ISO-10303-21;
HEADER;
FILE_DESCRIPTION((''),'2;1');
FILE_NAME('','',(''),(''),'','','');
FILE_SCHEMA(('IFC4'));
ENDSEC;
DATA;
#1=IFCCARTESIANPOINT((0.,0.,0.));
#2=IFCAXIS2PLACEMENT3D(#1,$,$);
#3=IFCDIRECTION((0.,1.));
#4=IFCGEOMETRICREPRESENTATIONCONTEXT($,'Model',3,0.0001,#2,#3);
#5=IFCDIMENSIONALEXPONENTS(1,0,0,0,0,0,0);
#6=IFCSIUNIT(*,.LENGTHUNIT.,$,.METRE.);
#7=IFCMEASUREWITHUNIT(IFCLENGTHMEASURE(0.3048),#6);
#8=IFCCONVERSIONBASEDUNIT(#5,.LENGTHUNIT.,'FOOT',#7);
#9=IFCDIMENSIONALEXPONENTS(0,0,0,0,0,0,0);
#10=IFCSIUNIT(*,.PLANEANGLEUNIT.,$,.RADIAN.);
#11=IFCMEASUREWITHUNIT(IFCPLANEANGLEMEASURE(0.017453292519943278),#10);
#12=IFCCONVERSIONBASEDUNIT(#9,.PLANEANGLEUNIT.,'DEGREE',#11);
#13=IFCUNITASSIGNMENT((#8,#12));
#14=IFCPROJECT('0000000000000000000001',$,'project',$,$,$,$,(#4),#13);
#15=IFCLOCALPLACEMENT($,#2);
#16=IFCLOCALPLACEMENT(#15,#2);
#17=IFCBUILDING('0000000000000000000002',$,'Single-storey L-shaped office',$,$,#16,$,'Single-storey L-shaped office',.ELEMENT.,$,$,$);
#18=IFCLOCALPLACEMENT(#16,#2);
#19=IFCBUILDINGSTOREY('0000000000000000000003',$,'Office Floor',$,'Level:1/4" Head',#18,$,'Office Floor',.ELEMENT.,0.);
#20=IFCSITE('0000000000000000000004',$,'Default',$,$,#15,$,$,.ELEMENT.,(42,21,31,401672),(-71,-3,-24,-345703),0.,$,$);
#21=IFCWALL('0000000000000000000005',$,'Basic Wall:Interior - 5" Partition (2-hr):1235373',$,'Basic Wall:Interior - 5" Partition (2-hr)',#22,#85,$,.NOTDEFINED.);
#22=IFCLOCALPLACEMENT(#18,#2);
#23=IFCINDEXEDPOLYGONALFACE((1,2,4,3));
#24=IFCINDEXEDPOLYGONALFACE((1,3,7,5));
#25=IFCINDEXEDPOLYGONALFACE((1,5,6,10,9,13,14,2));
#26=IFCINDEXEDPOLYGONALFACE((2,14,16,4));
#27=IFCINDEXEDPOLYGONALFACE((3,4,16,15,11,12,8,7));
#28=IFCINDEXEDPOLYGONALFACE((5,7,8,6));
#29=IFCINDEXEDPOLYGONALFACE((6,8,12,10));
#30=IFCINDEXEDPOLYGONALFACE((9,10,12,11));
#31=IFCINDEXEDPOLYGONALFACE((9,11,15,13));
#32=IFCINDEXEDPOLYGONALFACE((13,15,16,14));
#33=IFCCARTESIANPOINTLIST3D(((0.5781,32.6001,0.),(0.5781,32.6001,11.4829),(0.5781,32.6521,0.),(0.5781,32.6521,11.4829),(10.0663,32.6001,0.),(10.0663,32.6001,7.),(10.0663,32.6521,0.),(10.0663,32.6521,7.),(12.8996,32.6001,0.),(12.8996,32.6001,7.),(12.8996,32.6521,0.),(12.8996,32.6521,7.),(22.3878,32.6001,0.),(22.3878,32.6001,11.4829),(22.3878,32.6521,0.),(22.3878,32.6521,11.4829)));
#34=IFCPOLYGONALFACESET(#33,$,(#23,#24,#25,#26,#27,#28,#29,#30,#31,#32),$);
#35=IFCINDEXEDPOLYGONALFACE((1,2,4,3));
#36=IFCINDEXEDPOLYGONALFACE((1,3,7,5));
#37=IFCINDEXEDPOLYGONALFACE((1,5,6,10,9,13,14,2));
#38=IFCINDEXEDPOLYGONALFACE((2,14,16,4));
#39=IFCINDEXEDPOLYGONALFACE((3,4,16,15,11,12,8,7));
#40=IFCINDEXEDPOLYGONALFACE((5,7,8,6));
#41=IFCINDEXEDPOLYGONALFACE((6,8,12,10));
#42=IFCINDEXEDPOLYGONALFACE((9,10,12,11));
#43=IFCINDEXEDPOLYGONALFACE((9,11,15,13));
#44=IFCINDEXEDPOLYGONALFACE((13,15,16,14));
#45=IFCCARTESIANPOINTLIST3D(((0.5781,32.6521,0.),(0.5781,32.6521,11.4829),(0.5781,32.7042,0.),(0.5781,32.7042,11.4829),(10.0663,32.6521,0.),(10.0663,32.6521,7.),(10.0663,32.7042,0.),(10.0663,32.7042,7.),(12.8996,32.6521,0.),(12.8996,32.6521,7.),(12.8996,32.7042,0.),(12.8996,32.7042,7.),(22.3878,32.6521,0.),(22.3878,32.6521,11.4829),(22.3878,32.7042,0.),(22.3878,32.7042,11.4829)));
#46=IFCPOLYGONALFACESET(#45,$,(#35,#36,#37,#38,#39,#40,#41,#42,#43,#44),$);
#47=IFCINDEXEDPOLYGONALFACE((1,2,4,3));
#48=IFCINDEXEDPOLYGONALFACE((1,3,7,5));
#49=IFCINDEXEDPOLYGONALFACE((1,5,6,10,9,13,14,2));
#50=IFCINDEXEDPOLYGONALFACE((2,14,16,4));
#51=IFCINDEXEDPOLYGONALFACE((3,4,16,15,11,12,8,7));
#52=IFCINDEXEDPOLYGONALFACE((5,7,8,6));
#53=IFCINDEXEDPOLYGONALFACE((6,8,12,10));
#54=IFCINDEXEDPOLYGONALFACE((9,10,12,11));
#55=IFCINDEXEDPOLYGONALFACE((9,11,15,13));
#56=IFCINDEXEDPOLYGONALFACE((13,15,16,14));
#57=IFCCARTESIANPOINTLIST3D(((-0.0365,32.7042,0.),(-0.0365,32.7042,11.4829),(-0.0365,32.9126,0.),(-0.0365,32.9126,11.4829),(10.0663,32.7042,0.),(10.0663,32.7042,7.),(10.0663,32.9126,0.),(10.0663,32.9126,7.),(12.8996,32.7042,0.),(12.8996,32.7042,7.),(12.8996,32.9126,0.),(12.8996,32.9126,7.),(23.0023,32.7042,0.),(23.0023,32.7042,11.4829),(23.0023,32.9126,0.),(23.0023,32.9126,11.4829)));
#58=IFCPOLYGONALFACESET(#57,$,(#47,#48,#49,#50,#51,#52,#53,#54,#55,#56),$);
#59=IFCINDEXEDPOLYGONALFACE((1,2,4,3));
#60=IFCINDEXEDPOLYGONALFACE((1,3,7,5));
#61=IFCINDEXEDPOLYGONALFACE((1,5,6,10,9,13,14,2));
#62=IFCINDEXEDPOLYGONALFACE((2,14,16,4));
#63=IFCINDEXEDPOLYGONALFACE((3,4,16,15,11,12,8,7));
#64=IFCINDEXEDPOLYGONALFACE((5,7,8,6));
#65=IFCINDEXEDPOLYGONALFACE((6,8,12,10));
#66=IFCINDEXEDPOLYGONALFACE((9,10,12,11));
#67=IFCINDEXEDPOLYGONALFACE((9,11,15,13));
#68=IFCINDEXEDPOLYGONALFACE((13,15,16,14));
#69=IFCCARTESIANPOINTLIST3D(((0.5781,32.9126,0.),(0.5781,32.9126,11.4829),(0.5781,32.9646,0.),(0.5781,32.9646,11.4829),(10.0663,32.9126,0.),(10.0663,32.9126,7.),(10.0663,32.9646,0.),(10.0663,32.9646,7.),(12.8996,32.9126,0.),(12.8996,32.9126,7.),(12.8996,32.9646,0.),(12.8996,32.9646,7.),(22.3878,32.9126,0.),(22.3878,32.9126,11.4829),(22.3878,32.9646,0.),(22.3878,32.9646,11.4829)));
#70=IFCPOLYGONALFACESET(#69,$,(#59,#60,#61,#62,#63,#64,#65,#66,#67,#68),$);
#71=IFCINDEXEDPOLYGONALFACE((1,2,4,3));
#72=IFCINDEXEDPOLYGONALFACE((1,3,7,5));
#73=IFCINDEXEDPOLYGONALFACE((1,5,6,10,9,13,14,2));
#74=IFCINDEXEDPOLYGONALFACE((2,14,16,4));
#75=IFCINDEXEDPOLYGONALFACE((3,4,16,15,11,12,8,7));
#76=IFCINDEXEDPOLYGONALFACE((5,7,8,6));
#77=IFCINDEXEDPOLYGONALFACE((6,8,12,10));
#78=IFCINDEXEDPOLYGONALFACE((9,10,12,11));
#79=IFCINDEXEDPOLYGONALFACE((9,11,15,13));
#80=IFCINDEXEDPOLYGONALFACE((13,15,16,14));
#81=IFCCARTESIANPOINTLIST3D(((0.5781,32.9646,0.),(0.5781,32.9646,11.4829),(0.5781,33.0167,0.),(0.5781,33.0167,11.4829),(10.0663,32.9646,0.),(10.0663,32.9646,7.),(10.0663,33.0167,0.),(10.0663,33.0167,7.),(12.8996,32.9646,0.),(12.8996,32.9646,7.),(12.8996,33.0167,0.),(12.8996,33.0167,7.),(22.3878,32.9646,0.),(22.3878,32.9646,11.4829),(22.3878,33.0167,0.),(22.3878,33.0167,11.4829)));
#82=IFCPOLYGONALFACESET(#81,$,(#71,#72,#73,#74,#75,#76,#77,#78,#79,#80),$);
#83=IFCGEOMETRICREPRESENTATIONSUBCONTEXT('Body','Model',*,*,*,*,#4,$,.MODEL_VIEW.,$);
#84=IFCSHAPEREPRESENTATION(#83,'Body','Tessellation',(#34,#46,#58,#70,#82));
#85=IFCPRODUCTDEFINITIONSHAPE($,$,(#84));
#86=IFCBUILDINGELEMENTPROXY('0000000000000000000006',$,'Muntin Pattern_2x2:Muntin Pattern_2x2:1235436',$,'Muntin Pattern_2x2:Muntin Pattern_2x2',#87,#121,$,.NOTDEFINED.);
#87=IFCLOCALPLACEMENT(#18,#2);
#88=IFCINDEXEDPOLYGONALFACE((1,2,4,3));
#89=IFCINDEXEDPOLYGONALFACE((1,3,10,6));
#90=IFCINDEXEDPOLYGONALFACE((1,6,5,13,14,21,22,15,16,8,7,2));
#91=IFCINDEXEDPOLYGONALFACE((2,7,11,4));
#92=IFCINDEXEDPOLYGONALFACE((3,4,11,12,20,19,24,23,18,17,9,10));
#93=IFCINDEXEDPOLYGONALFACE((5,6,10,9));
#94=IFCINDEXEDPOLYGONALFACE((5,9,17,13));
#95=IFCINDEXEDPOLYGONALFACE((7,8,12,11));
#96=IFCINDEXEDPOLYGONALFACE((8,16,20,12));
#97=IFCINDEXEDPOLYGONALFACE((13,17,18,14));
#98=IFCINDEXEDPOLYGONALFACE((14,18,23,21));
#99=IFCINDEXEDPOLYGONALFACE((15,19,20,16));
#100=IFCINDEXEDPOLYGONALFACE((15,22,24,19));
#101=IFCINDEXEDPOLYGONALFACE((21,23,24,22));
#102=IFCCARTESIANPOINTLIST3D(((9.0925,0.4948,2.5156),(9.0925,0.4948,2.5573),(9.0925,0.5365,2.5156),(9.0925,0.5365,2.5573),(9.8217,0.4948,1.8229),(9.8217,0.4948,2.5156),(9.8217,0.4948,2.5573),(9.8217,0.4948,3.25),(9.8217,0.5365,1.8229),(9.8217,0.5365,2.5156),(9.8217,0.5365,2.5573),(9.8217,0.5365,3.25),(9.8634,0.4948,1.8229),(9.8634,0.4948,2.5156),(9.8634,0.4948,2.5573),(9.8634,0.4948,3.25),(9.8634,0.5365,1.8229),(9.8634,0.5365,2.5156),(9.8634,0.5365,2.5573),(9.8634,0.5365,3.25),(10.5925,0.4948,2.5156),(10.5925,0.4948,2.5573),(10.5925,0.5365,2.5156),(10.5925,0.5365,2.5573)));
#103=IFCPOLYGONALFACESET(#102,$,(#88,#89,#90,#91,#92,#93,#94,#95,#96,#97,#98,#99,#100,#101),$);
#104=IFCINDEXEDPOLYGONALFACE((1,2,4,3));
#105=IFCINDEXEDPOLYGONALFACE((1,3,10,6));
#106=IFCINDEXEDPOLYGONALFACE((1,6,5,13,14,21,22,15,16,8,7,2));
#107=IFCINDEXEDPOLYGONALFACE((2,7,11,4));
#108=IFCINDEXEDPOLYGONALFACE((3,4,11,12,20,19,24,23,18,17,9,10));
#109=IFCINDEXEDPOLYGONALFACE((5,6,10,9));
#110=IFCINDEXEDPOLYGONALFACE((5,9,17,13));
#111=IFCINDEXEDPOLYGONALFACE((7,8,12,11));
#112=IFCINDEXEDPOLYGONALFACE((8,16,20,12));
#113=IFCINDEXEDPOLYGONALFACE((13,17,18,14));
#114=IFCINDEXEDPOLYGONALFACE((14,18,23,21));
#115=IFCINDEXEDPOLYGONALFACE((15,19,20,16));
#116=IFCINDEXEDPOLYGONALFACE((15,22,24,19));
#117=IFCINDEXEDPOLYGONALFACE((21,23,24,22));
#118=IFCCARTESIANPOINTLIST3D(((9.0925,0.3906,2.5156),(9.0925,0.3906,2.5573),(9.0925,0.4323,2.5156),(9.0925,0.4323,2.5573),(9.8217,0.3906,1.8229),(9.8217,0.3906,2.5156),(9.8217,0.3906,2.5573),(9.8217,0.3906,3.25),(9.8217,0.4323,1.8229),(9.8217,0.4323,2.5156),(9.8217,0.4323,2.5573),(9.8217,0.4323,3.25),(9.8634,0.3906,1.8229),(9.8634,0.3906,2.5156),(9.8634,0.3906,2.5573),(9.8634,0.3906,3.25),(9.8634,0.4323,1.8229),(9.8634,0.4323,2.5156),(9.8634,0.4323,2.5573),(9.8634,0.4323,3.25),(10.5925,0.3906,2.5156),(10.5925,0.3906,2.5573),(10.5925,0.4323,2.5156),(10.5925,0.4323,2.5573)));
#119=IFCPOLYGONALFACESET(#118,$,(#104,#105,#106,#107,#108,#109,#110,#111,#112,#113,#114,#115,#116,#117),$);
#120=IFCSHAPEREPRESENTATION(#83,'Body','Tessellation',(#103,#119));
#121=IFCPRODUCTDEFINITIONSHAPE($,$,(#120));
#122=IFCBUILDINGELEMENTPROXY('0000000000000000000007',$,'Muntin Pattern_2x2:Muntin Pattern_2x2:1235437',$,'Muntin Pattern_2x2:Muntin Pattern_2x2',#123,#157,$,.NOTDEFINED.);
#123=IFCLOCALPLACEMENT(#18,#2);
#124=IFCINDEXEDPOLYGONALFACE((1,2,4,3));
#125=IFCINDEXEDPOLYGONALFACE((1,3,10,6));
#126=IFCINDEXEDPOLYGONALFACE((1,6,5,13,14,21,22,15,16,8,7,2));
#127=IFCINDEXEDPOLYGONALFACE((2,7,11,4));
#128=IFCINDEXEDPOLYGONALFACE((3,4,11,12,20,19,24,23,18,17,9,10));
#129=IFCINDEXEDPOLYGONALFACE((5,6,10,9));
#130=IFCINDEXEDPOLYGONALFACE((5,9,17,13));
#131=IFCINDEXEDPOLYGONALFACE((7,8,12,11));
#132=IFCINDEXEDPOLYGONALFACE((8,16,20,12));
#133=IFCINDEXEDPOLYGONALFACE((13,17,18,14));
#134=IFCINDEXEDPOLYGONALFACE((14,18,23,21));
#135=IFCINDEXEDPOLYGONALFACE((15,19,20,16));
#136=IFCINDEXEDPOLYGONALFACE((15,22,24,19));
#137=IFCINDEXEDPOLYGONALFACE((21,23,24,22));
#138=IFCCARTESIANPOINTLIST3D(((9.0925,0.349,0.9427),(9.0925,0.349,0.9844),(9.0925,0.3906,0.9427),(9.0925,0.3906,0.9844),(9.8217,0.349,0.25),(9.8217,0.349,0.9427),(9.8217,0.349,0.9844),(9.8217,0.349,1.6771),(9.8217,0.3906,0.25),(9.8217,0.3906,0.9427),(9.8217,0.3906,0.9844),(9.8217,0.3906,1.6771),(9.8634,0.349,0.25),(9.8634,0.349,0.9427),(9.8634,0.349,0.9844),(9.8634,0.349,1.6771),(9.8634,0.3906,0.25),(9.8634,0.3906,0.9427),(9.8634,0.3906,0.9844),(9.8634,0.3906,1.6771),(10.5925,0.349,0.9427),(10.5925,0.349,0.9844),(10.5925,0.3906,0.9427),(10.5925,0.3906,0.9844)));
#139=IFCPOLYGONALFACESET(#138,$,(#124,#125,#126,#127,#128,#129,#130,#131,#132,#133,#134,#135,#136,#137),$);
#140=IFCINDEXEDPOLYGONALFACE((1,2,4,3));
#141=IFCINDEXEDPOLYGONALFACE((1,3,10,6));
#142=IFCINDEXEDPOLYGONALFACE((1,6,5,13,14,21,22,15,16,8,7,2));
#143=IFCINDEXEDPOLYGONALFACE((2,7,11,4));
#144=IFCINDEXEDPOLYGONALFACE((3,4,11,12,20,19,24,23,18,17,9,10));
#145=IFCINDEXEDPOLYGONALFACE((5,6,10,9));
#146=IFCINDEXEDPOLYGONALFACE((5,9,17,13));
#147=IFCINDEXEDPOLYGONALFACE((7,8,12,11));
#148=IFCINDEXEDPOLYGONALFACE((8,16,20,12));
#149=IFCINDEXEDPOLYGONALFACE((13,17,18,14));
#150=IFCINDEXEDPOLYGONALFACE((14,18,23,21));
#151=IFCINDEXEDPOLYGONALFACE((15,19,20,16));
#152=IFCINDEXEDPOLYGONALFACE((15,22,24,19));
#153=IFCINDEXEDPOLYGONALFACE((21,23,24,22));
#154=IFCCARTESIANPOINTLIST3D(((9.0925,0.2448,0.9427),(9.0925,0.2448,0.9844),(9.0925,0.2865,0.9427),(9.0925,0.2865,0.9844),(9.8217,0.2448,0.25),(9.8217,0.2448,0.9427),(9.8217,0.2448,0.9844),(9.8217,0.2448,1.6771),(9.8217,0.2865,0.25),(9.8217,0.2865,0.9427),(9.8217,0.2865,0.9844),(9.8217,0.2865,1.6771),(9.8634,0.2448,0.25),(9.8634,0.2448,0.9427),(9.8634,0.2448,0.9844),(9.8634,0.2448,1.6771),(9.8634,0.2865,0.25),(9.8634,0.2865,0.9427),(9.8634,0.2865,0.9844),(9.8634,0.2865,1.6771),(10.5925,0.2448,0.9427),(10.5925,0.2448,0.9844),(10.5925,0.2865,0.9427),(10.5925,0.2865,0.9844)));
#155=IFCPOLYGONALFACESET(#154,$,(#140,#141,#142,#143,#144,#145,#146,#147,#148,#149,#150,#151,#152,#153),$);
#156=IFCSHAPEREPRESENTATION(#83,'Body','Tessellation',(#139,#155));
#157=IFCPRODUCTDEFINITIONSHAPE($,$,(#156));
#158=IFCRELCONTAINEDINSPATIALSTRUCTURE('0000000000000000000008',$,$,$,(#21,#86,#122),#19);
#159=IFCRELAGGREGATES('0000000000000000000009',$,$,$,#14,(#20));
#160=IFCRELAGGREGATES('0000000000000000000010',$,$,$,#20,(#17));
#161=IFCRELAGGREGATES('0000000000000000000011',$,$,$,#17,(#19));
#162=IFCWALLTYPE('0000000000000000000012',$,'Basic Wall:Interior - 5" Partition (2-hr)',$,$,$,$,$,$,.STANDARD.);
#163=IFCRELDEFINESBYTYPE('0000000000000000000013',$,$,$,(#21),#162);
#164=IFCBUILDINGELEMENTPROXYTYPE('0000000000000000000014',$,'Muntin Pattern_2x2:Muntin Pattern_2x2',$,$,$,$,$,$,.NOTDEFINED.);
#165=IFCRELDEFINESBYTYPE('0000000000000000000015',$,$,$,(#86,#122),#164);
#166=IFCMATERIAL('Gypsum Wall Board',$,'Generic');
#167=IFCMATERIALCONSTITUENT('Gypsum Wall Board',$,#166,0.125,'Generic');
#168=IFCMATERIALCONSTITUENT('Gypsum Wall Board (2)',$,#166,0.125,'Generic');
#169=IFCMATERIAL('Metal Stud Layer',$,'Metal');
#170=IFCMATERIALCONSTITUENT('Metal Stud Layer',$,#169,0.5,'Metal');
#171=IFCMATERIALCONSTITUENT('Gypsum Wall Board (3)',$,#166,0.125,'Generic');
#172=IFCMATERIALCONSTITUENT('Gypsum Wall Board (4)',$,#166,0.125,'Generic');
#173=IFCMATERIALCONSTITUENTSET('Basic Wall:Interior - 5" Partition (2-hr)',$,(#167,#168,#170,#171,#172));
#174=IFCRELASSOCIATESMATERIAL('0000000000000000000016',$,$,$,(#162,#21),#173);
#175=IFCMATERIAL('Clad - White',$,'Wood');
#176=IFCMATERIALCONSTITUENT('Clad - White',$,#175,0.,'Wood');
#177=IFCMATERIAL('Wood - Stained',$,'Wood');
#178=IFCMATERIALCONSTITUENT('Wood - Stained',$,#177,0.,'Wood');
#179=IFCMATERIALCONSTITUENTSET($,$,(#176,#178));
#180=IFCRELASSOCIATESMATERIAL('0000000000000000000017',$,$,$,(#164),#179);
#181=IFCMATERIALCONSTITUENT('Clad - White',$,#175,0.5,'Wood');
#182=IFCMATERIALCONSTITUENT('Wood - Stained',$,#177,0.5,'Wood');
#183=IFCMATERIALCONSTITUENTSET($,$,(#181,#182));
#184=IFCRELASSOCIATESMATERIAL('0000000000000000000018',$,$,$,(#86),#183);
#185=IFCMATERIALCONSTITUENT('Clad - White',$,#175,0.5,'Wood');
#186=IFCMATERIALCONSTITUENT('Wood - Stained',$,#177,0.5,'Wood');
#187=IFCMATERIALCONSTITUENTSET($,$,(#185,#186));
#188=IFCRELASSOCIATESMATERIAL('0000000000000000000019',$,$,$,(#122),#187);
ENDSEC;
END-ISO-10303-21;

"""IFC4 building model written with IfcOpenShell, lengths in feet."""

from ifc_helpers import new_model, entity, si_unit, converted_unit, direction, frame, origin, place, context, subcontext, project, spatial, indexed_curve, outline, extrude, source, transform, mapped, material, constituent, constituent_set, type_object, type_shapes, element, save


model = new_model("IFC4")

# Units and contexts
model_context = context("Model", 3, precision=0.0001, world=origin(), true_north=direction((0.0, 1.0)))
body_context = subcontext(model_context, "Body", "Model", "MODEL_VIEW")
ifc_project = project(units=[converted_unit("LENGTHUNIT", "FOOT", entity("IfcLengthMeasure", 0.3048), si_unit("LENGTHUNIT", "METRE"), dimensions=[1, 0, 0, 0, 0, 0, 0]), converted_unit("PLANEANGLEUNIT", "DEGREE", entity("IfcPlaneAngleMeasure", 0.017453292519943278), si_unit("PLANEANGLEUNIT", "RADIAN"), dimensions=[0, 0, 0, 0, 0, 0, 0])], contexts=[model_context])

# Site, building, storey
site_placement = place(None, origin())
site = spatial("IfcSite", under=ifc_project, at=site_placement, Name="Default", CompositionType="ELEMENT", RefLatitude=(42, 21, 31, 401672), RefLongitude=(-71, -3, -24, -345703), RefElevation=0.0)
building_placement = place(site_placement, origin())
building = spatial("IfcBuilding", under=site, at=building_placement, Name="Single-storey L-shaped office", LongName="Single-storey L-shaped office", CompositionType="ELEMENT")
storey_placement = place(building_placement, origin())
storey = spatial("IfcBuildingStorey", under=building, at=storey_placement, Name="Office Floor", ObjectType="Level:1/4\" Head", LongName="Office Floor", CompositionType="ELEMENT", Elevation=0.0)

# Shared definitions
ifc_material_1 = material(Name="Metal Stud Layer", Category="Metal")
ifc_material_2 = material(Name="Gypsum Wall Board", Category="Generic")
ifc_material_3 = material(Name="Wood - Stained", Category="Wood")

# Wall, opening
ifc_constituent_1 = constituent(ifc_material_2, Name="Gypsum Wall Board", Category="Generic", fraction=0.125)
ifc_constituent_2 = constituent(ifc_material_2, Name="Gypsum Wall Board (2)", Category="Generic", fraction=0.125)
ifc_constituent_3 = constituent(ifc_material_1, Name="Metal Stud Layer", Category="Metal", fraction=0.5)
ifc_constituent_4 = constituent(ifc_material_2, Name="Gypsum Wall Board (3)", Category="Generic", fraction=0.125)
ifc_constituent_5 = constituent(ifc_material_2, Name="Gypsum Wall Board (4)", Category="Generic", fraction=0.125)
ifc_constituent_set_1 = constituent_set(constituents=[ifc_constituent_1, ifc_constituent_2, ifc_constituent_3, ifc_constituent_4, ifc_constituent_5], Name="Basic Wall:Interior - 5\" Partition (2-hr)")
wall_type_1 = type_object("IfcWallType", Name="Basic Wall:Interior - 5\" Partition (2-hr)", PredefinedType="STANDARD", material=ifc_constituent_set_1)
wall_1_placement = place(storey_placement, frame((0.5781, 32.8084, 0.0)))
wall_1 = element("IfcWall", 1, at=wall_1_placement, inside=storey, type_object=wall_type_1, material=ifc_constituent_set_1, Name="Basic Wall:Interior - 5\" Partition (2-hr):1235373", ObjectType="Basic Wall:Interior - 5\" Partition (2-hr)", PredefinedType="NOTDEFINED", context=body_context, shape_type="SweptSolid", body=[
    extrude(outline(indexed_curve([(-6.8622, -10.9048), (4.6207, -10.9048), (4.6207, -1.4167), (-2.3793, -1.4167), (-2.3793, 1.4167), (4.6207, 1.4167), (4.6207, 10.9048), (-6.8622, 10.9048), (-6.8622, -10.9048)], self_intersect=False)), frame((10.9048, -0.2083, 4.6207), z_axis=(0.0, 1.0, 0.0), x_axis=(0.0, 0.0, -1.0)), (0.0, 0.0, 1.0), 0.0521),
    extrude(outline(indexed_curve([(-4.6207, -10.9048), (6.8622, -10.9048), (6.8622, 10.9048), (-4.6207, 10.9048), (-4.6207, 1.4167), (2.3793, 1.4167), (2.3793, -1.4167), (-4.6207, -1.4167), (-4.6207, -10.9048)], self_intersect=False)), frame((10.9048, -0.1562, 4.6207), z_axis=(0.0, 1.0, 0.0), x_axis=(0.0, 0.0, 1.0)), (0.0, 0.0, 1.0), 0.0521),
    extrude(outline(indexed_curve([(-4.6207, -11.5194), (6.8622, -11.5194), (6.8622, 11.5194), (-4.6207, 11.5194), (-4.6207, 1.4167), (2.3793, 1.4167), (2.3793, -1.4167), (-4.6207, -1.4167), (-4.6207, -11.5194)], self_intersect=False)), frame((10.9048, -0.1042, 4.6207), z_axis=(0.0, 1.0, 0.0), x_axis=(0.0, 0.0, 1.0)), (0.0, 0.0, 1.0), 0.2083),
    extrude(outline(indexed_curve([(-4.6207, -10.9048), (6.8622, -10.9048), (6.8622, 10.9048), (-4.6207, 10.9048), (-4.6207, 1.4167), (2.3793, 1.4167), (2.3793, -1.4167), (-4.6207, -1.4167), (-4.6207, -10.9048)], self_intersect=False)), frame((10.9048, 0.1042, 4.6207), z_axis=(0.0, 1.0, 0.0), x_axis=(0.0, 0.0, 1.0)), (0.0, 0.0, 1.0), 0.0521),
    extrude(outline(indexed_curve([(-4.6207, -10.9048), (6.8622, -10.9048), (6.8622, 10.9048), (-4.6207, 10.9048), (-4.6207, 1.4167), (2.3793, 1.4167), (2.3793, -1.4167), (-4.6207, -1.4167), (-4.6207, -10.9048)], self_intersect=False)), frame((10.9048, 0.1562, 4.6207), z_axis=(0.0, 1.0, 0.0), x_axis=(0.0, 0.0, 1.0)), (0.0, 0.0, 1.0), 0.0521),
])
opening_1_placement = place(wall_1_placement, frame((9.4881, -0.2083, 0.0)))
element("IfcOpeningElement", 2, at=opening_1_placement, cuts=wall_1, PredefinedType="OPENING", context=body_context, shape_type="SweptSolid", body=[
    extrude(outline(indexed_curve([(0.0, 2.8333), (0.0, 0.0), (7.0, 0.0), (7.0, 2.8333), (0.0, 2.8333)], self_intersect=False)), frame((0.0, 0.0, 0.0), z_axis=(0.0, 1.0, 0.0), x_axis=(0.0, 0.0, 1.0)), (0.0, 0.0, 1.0), 0.4167),
])

# Building element proxies
ifc_material_4 = material(Name="Clad - White", Category="Wood")
ifc_constituent_6 = constituent(ifc_material_4, Name="Clad - White", Category="Wood", fraction=0.5)
ifc_constituent_7 = constituent(ifc_material_3, Name="Wood - Stained", Category="Wood", fraction=0.5)
ifc_constituent_set_2 = constituent_set(constituents=[ifc_constituent_6, ifc_constituent_7])
ifc_constituent_8 = constituent(ifc_material_4, Name="Clad - White", Category="Wood", fraction=0.0)
ifc_constituent_9 = constituent(ifc_material_3, Name="Wood - Stained", Category="Wood", fraction=0.0)
ifc_constituent_set_3 = constituent_set(constituents=[ifc_constituent_8, ifc_constituent_9])
building_element_proxy_type_1 = type_object("IfcBuildingElementProxyType", Name="Muntin Pattern_2x2:Muntin Pattern_2x2", PredefinedType="NOTDEFINED", material=ifc_constituent_set_3)
shared_shape_1 = source(origin(), body_context, "Body", "SweptSolid", [
    extrude(outline(indexed_curve([(0.0208, -0.0208), (0.7135, -0.0208), (0.7135, 0.0208), (0.0208, 0.0208), (0.0208, 0.75), (-0.0208, 0.75), (-0.0208, 0.0208), (-0.7135, 0.0208), (-0.7135, -0.0208), (-0.0208, -0.0208), (-0.0208, -0.75), (0.0208, -0.75), (0.0208, -0.0208)], self_intersect=False)), frame((0.0, 0.0312, 0.7135), z_axis=(0.0, 1.0, 0.0), x_axis=(0.0, 0.0, 1.0)), (0.0, 0.0, 1.0), 0.0417),
    extrude(outline(indexed_curve([(0.0208, -0.0208), (0.7135, -0.0208), (0.7135, 0.0208), (0.0208, 0.0208), (0.0208, 0.75), (-0.0208, 0.75), (-0.0208, 0.0208), (-0.7135, 0.0208), (-0.7135, -0.0208), (-0.0208, -0.0208), (-0.0208, -0.75), (0.0208, -0.75), (0.0208, -0.0208)], self_intersect=False)), frame((0.0, -0.0729, 0.7135), z_axis=(0.0, 1.0, 0.0), x_axis=(0.0, 0.0, 1.0)), (0.0, 0.0, 1.0), 0.0417),
])
type_shapes(building_element_proxy_type_1, [shared_shape_1])
proxy_1_placement = place(storey_placement, frame((9.8425, 0.4635, 1.8229)))
element("IfcBuildingElementProxy", 3, at=proxy_1_placement, inside=storey, type_object=building_element_proxy_type_1, material=ifc_constituent_set_2, Name="Muntin Pattern_2x2:Muntin Pattern_2x2:1235436", ObjectType="Muntin Pattern_2x2:Muntin Pattern_2x2", PredefinedType="NOTDEFINED", context=body_context, shape_type="MappedRepresentation", body=[
    mapped(shared_shape_1, transform((0.0, 0.0, 0.0), scale=1.0)),
])
ifc_constituent_10 = constituent(ifc_material_4, Name="Clad - White", Category="Wood", fraction=0.5)
ifc_constituent_11 = constituent(ifc_material_3, Name="Wood - Stained", Category="Wood", fraction=0.5)
ifc_constituent_set_4 = constituent_set(constituents=[ifc_constituent_10, ifc_constituent_11])
proxy_2_placement = place(storey_placement, frame((9.8425, 0.3177, 0.25)))
element("IfcBuildingElementProxy", 4, at=proxy_2_placement, inside=storey, type_object=building_element_proxy_type_1, material=ifc_constituent_set_4, Name="Muntin Pattern_2x2:Muntin Pattern_2x2:1235437", ObjectType="Muntin Pattern_2x2:Muntin Pattern_2x2", PredefinedType="NOTDEFINED", context=body_context, shape_type="MappedRepresentation", body=[
    mapped(shared_shape_1, transform((0.0, 0.0, 0.0), scale=1.0)),
])

save(model, "model.ifc")
